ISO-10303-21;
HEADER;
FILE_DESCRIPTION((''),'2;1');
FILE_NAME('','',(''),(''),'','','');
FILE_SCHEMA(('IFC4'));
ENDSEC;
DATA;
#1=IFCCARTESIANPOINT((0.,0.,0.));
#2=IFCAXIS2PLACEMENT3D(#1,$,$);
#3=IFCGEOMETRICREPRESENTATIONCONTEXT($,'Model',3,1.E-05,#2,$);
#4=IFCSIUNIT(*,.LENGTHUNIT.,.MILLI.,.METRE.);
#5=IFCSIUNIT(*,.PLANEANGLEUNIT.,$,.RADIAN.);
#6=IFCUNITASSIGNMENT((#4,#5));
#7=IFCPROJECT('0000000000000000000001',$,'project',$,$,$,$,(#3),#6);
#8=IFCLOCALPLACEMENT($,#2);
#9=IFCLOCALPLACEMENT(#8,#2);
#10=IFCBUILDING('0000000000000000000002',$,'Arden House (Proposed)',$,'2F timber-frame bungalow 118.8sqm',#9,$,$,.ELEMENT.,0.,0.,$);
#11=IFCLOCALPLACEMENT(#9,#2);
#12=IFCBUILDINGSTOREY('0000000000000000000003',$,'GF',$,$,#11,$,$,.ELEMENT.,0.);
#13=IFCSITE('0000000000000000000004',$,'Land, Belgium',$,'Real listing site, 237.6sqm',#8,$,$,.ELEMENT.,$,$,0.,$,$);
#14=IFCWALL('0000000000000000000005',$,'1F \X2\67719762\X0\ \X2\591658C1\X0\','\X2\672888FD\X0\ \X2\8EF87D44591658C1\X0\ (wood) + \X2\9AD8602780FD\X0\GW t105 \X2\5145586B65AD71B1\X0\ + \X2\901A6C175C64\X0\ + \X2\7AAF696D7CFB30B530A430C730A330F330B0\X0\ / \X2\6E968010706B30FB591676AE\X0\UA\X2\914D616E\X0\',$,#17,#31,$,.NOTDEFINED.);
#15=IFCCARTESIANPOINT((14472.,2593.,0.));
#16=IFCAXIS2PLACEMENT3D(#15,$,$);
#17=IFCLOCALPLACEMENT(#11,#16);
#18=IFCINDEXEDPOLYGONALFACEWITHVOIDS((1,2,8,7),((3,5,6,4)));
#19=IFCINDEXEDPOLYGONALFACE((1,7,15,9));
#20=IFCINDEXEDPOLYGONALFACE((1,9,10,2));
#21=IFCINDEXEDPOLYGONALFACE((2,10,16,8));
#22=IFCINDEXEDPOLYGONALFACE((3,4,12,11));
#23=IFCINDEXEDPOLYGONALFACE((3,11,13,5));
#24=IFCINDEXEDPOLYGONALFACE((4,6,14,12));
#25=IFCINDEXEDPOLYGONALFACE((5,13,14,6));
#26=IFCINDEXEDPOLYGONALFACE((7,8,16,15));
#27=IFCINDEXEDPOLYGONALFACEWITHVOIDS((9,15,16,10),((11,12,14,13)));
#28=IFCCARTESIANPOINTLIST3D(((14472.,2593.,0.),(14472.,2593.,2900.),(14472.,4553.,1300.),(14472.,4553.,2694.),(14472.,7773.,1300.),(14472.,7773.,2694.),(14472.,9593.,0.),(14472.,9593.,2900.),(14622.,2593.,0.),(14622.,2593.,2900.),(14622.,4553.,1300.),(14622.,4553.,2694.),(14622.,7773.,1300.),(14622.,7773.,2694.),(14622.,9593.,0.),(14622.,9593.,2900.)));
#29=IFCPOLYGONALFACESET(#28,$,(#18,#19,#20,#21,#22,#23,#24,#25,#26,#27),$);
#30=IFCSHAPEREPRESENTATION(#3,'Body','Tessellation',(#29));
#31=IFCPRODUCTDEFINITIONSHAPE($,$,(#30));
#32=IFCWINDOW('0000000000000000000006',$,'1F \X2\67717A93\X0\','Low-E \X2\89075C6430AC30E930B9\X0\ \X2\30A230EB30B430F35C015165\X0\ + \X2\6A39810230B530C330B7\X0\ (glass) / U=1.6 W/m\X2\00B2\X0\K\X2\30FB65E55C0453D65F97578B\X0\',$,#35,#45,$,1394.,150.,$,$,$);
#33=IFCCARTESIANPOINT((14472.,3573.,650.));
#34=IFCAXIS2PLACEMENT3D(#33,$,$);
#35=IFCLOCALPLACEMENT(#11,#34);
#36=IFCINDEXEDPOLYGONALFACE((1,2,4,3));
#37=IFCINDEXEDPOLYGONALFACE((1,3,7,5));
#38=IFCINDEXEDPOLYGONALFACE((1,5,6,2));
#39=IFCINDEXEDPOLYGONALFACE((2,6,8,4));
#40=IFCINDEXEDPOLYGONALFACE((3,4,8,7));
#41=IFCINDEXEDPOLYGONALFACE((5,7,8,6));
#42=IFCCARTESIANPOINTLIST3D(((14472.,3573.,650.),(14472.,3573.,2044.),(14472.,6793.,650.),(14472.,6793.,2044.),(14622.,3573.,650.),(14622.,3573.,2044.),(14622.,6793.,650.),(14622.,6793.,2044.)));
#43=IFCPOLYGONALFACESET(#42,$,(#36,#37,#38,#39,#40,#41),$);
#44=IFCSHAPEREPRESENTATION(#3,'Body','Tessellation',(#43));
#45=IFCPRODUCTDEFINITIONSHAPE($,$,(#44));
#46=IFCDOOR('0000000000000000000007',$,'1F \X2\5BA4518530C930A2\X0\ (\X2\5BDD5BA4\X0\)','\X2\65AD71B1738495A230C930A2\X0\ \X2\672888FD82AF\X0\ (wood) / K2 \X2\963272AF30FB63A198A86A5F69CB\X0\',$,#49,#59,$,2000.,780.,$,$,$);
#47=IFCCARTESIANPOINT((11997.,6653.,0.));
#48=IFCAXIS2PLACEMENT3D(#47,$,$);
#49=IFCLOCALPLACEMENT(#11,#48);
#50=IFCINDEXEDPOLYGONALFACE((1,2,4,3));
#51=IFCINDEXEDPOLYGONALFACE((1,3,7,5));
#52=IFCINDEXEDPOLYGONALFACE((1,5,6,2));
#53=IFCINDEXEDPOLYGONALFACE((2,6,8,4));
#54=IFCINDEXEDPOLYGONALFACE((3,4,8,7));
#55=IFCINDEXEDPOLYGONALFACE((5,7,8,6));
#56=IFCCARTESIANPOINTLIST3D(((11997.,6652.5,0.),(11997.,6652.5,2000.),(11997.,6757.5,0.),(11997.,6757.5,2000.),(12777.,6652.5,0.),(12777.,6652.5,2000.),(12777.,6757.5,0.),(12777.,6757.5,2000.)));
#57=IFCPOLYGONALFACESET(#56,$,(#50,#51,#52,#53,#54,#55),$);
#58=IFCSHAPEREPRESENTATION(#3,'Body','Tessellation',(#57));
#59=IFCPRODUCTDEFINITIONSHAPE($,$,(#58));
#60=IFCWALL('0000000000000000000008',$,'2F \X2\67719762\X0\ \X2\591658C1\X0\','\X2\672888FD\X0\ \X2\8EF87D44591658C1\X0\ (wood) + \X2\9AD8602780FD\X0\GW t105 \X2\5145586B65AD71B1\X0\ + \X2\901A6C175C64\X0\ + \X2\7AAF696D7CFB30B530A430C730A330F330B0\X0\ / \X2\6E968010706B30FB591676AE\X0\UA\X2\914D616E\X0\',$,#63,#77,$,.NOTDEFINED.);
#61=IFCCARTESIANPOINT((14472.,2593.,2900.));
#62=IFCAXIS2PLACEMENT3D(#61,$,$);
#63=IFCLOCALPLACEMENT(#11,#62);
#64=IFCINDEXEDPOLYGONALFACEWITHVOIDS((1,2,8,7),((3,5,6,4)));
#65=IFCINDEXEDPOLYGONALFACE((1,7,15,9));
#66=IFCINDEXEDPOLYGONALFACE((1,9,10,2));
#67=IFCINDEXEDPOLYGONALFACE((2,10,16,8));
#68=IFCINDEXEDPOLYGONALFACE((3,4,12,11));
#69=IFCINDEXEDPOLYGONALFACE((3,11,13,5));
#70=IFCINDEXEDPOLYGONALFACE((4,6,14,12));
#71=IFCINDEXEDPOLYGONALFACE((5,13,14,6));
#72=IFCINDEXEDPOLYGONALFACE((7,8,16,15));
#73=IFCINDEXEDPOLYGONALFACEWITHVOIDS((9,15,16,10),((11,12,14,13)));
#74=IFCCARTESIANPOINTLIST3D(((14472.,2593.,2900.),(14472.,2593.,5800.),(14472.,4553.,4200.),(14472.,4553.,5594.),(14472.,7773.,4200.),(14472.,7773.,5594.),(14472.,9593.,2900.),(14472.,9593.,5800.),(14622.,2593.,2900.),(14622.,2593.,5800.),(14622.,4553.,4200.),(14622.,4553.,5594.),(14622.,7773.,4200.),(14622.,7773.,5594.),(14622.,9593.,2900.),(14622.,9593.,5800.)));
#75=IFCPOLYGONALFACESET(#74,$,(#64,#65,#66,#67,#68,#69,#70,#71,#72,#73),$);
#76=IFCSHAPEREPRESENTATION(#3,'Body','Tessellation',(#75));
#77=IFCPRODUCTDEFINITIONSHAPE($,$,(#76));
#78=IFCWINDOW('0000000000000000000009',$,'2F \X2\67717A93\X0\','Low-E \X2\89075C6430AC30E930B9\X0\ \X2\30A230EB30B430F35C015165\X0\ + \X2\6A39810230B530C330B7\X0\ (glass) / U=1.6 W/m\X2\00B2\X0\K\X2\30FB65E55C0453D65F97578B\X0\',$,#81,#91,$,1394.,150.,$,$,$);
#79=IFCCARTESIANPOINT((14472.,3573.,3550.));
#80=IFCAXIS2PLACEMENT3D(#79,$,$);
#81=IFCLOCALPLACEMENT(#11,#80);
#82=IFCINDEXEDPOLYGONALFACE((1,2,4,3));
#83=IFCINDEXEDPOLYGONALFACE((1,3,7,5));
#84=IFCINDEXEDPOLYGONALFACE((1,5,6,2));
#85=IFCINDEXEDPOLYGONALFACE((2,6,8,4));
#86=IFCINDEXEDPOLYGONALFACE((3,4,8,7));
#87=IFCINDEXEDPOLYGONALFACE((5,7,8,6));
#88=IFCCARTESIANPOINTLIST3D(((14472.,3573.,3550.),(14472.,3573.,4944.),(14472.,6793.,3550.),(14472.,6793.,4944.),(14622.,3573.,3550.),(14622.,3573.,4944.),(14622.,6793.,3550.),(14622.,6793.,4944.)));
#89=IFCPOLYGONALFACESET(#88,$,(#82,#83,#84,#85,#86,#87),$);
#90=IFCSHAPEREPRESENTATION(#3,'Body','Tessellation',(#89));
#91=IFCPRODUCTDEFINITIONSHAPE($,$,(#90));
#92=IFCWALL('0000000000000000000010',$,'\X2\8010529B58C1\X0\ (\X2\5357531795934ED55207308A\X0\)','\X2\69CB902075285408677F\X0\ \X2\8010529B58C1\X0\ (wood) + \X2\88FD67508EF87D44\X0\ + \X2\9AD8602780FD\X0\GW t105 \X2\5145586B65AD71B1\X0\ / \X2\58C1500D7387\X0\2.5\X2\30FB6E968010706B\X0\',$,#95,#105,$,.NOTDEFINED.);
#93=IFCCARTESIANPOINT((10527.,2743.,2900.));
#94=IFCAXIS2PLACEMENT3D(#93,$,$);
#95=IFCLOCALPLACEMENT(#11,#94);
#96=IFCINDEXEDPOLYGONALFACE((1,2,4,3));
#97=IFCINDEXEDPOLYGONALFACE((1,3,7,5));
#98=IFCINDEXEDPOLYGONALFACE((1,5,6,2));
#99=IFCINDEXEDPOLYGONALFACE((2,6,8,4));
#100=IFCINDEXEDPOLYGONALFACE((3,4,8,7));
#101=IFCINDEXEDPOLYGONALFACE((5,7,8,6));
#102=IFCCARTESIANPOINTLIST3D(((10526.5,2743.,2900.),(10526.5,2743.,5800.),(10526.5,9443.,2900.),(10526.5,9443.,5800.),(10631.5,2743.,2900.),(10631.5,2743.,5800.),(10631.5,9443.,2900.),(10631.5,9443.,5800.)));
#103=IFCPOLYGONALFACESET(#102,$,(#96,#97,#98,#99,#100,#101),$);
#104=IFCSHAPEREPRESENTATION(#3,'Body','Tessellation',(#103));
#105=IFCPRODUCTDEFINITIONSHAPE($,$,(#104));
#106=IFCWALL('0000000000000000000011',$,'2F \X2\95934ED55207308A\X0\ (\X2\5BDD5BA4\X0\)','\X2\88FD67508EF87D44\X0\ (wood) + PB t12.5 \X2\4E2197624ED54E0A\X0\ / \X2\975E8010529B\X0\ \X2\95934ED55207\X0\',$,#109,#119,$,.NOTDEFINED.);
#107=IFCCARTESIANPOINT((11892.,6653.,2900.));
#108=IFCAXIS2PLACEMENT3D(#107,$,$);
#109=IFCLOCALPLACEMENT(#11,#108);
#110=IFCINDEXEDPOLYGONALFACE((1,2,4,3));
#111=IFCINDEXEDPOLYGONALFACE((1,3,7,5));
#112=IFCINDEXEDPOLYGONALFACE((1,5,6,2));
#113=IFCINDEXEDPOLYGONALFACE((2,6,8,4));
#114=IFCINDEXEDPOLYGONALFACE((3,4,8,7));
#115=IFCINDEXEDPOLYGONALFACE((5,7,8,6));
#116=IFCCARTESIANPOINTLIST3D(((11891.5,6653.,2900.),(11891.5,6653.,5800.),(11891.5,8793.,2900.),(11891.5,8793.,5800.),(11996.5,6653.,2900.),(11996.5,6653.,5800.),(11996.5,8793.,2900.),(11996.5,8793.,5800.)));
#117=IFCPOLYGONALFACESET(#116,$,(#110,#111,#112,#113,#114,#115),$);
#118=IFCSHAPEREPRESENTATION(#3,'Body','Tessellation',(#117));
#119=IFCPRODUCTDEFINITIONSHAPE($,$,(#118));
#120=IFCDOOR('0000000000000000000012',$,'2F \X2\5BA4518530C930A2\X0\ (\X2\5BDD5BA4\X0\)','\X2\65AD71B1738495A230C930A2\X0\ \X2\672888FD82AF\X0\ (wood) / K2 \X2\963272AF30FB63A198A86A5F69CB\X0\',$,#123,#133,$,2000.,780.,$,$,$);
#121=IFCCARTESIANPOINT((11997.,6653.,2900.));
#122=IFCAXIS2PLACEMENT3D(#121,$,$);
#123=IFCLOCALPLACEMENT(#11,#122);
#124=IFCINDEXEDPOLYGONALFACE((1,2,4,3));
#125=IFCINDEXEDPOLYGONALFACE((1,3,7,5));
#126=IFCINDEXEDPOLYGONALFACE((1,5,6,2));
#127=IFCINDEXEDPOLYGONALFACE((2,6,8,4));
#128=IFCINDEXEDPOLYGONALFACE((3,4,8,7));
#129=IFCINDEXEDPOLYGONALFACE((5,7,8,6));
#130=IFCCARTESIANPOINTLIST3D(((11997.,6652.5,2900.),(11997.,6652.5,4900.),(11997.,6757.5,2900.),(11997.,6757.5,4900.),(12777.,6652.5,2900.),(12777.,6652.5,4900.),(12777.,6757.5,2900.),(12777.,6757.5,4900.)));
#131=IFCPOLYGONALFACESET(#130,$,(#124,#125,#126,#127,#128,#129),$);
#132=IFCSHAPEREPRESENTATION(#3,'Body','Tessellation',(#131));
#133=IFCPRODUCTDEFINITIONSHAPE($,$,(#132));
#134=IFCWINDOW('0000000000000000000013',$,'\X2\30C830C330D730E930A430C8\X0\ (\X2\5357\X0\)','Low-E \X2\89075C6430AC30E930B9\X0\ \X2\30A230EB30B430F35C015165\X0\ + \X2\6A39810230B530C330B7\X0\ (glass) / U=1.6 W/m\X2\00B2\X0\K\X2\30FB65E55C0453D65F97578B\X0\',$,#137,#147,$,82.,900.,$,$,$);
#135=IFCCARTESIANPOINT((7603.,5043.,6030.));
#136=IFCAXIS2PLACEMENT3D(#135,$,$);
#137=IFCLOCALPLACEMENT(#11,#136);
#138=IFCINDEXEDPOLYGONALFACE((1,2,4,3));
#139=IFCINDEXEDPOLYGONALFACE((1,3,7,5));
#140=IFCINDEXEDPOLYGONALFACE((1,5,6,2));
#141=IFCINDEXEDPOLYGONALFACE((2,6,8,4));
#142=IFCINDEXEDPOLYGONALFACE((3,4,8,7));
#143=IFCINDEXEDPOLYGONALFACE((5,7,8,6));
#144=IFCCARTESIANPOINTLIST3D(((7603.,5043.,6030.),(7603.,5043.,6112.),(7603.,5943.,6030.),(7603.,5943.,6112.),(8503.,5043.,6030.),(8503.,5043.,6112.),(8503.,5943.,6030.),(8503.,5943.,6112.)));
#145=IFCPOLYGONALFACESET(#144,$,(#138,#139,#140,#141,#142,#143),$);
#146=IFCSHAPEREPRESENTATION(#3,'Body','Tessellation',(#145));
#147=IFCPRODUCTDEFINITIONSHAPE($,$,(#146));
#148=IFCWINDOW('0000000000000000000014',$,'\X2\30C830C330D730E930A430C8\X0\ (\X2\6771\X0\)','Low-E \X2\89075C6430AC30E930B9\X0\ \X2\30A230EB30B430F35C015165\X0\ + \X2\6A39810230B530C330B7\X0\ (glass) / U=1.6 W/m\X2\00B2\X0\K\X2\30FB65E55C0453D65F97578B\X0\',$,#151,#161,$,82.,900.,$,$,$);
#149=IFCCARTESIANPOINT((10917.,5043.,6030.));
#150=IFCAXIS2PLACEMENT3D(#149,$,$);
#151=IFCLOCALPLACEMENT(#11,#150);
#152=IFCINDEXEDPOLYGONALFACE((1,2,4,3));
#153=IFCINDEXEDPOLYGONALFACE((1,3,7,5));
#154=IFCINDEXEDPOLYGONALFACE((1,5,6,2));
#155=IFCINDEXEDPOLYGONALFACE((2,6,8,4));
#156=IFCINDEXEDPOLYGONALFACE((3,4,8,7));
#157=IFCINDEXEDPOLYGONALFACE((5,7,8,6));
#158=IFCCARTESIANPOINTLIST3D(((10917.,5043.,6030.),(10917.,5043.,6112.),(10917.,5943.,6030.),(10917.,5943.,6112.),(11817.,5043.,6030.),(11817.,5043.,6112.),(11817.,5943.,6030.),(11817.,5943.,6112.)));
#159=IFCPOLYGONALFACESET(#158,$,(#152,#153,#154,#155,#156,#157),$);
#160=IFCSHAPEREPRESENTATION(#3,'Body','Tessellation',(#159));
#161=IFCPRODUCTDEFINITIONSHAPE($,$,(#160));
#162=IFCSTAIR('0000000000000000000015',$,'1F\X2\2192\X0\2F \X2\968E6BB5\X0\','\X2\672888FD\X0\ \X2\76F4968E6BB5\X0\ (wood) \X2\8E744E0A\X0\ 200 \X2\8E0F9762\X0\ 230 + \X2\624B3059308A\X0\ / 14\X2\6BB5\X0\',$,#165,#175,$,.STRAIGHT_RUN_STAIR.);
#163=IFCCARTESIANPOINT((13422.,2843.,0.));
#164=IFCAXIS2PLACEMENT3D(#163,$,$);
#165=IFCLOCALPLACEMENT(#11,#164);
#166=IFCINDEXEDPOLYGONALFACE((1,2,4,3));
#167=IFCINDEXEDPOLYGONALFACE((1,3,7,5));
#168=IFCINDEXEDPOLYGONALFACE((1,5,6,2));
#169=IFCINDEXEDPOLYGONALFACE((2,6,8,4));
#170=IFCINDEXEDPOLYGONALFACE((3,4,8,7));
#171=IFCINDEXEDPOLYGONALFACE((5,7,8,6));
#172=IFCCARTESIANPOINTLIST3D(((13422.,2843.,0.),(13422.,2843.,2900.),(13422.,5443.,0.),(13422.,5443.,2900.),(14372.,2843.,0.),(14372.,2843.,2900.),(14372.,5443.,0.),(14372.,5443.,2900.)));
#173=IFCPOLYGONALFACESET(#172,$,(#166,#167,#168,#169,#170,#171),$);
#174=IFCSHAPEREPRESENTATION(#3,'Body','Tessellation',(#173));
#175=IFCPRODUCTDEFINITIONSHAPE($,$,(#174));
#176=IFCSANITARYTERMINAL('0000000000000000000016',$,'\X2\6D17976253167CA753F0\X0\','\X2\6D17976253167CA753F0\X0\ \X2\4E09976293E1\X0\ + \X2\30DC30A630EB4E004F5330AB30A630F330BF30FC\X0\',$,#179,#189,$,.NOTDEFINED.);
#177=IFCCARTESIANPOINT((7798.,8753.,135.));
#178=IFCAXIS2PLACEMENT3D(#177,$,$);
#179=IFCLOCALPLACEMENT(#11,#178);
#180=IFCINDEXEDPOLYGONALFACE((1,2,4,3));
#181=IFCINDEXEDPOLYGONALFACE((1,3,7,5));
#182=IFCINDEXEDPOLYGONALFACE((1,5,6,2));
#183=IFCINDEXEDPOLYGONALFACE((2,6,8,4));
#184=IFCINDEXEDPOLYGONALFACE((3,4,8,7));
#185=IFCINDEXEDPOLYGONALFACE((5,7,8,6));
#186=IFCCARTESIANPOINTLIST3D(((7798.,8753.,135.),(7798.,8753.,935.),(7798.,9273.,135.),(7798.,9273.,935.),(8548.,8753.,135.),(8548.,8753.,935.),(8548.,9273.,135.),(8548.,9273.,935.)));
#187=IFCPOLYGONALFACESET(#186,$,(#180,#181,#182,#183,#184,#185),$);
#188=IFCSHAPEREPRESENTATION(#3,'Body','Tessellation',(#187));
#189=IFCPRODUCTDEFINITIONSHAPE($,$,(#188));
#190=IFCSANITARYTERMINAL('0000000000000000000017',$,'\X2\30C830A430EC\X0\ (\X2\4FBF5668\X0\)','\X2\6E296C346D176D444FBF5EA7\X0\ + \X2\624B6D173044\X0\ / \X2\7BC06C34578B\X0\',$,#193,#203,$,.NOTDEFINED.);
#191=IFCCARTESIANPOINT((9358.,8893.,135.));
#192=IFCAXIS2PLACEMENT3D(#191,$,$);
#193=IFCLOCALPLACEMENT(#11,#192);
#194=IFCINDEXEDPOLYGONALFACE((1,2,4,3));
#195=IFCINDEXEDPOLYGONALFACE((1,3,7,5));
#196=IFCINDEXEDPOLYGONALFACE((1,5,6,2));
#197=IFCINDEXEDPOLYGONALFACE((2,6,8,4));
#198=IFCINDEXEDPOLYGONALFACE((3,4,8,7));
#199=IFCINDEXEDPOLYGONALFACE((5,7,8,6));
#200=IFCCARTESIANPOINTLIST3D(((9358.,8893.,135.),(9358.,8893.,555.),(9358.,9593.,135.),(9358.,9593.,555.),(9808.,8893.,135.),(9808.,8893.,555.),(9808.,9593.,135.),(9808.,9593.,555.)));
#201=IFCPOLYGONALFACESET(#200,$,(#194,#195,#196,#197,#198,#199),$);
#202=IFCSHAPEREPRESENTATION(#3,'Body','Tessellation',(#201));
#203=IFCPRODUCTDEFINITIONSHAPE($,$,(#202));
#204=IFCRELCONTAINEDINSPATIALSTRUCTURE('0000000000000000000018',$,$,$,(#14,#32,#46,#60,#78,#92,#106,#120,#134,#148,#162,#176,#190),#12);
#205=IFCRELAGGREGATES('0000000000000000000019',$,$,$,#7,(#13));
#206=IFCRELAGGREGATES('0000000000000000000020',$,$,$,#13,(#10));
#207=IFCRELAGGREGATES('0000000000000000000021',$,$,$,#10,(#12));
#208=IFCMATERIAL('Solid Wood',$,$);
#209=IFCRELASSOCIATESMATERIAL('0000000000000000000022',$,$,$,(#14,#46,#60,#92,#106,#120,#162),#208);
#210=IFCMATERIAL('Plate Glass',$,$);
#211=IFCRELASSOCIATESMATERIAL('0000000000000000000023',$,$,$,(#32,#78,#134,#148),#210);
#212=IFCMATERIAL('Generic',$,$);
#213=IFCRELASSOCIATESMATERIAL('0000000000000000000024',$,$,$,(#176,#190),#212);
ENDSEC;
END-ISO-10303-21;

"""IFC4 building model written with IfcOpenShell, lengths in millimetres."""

from ifc_helpers import new_model, si_unit, frame, frame_2d, origin, place, context, project, spatial, rectangle, extrude, material, element, fill, save


model = new_model("IFC4")

# Units and contexts
model_context = context("Model", 3, precision=1e-05, world=origin())
ifc_project = project(units=[si_unit("LENGTHUNIT", "METRE", prefix="MILLI"), si_unit("PLANEANGLEUNIT", "RADIAN")], contexts=[model_context])

# Site, building, storey
site_placement = place(None, origin())
site = spatial("IfcSite", under=ifc_project, at=site_placement, Name="Land, Belgium", ObjectType="Real listing site, 237.6sqm", CompositionType="ELEMENT", RefElevation=0.0)
building_placement = place(site_placement, origin())
building = spatial("IfcBuilding", under=site, at=building_placement, Name="Arden House (Proposed)", ObjectType="2F timber-frame bungalow 118.8sqm", CompositionType="ELEMENT", ElevationOfRefHeight=0.0, ElevationOfTerrain=0.0)
storey_placement = place(building_placement, origin())
storey = spatial("IfcBuildingStorey", under=building, at=storey_placement, Name="GF", CompositionType="ELEMENT", Elevation=0.0)

# Wall, opening, window
ifc_material_1 = material(Name="Solid Wood")
wall_1_placement = place(storey_placement, frame((14472.0, 2593.0, 0.0)))
wall_1 = element("IfcWall", 1, at=wall_1_placement, inside=storey, material=ifc_material_1, Name="1F 東面 外壁", Description="木製 軸組外壁 (wood) + 高性能GW t105 充填断熱 + 通気層 + 窯業系サイディング / 準耐火・外皮UA配慮", PredefinedType="NOTDEFINED", context=model_context, shape_type="SweptSolid", body=[
    extrude(rectangle(XDim=150.0, YDim=7000.0, at=frame_2d((75.0, 3500.0))), frame((14472.0, 2593.0, 0.0)), (0.0, 0.0, 1.0), 2900.0),
])
opening_1_placement = place(storey_placement, frame((14472.0, 3573.0, 650.0)))
opening_1 = element("IfcOpeningElement", 2, at=opening_1_placement, cuts=wall_1, PredefinedType="NOTDEFINED", context=model_context, shape_type="SweptSolid", body=[
    extrude(rectangle(XDim=150.0, YDim=3220.0, at=frame_2d((75.0, 1610.0))), frame((14472.0, 3573.0, 650.0)), (0.0, 0.0, 1.0), 1394.0),
])
ifc_material_2 = material(Name="Plate Glass")
window_1_placement = place(storey_placement, frame((14472.0, 3573.0, 650.0)))
window_1 = element("IfcWindow", 3, at=window_1_placement, inside=storey, material=ifc_material_2, Name="1F 東窓", Description="Low-E 複層ガラス アルゴン封入 + 樹脂サッシ (glass) / U=1.6 W/m²K・日射取得型", OverallHeight=1394.0, OverallWidth=150.0, context=model_context, shape_type="SweptSolid", body=[
    extrude(rectangle(XDim=150.0, YDim=3220.0, at=frame_2d((75.0, 1610.0))), frame((14472.0, 3573.0, 650.0)), (0.0, 0.0, 1.0), 1394.0),
])
fill(opening_1, window_1)

# Door
door_1_placement = place(storey_placement, frame((11997.0, 6653.0, 0.0)))
element("IfcDoor", 4, at=door_1_placement, inside=storey, material=ifc_material_1, Name="1F 室内ドア (寝室)", Description="断熱玄関ドア 木製芯 (wood) / K2 防犯・採風機構", OverallHeight=2000.0, OverallWidth=780.0, context=model_context, shape_type="SweptSolid", body=[
    extrude(rectangle(XDim=780.0, YDim=105.0, at=frame_2d((390.0, 52.0))), frame((11997.0, 6653.0, 0.0)), (0.0, 0.0, 1.0), 2000.0),
])

# Wall, opening, window
wall_2_placement = place(storey_placement, frame((14472.0, 2593.0, 2900.0)))
wall_2 = element("IfcWall", 5, at=wall_2_placement, inside=storey, material=ifc_material_1, Name="2F 東面 外壁", Description="木製 軸組外壁 (wood) + 高性能GW t105 充填断熱 + 通気層 + 窯業系サイディング / 準耐火・外皮UA配慮", PredefinedType="NOTDEFINED", context=model_context, shape_type="SweptSolid", body=[
    extrude(rectangle(XDim=150.0, YDim=7000.0, at=frame_2d((75.0, 3500.0))), frame((14472.0, 2593.0, 2900.0)), (0.0, 0.0, 1.0), 2900.0),
])
opening_2_placement = place(storey_placement, frame((14472.0, 3573.0, 3550.0)))
opening_2 = element("IfcOpeningElement", 6, at=opening_2_placement, cuts=wall_2, PredefinedType="NOTDEFINED", context=model_context, shape_type="SweptSolid", body=[
    extrude(rectangle(XDim=150.0, YDim=3220.0, at=frame_2d((75.0, 1610.0))), frame((14472.0, 3573.0, 3550.0)), (0.0, 0.0, 1.0), 1394.0),
])
window_2_placement = place(storey_placement, frame((14472.0, 3573.0, 3550.0)))
window_2 = element("IfcWindow", 7, at=window_2_placement, inside=storey, material=ifc_material_2, Name="2F 東窓", Description="Low-E 複層ガラス アルゴン封入 + 樹脂サッシ (glass) / U=1.6 W/m²K・日射取得型", OverallHeight=1394.0, OverallWidth=150.0, context=model_context, shape_type="SweptSolid", body=[
    extrude(rectangle(XDim=150.0, YDim=3220.0, at=frame_2d((75.0, 1610.0))), frame((14472.0, 3573.0, 3550.0)), (0.0, 0.0, 1.0), 1394.0),
])
fill(opening_2, window_2)

# Walls
wall_3_placement = place(storey_placement, frame((10527.0, 2743.0, 2900.0)))
element("IfcWall", 8, at=wall_3_placement, inside=storey, material=ifc_material_1, Name="耐力壁 (南北間仕切り)", Description="構造用合板 耐力壁 (wood) + 製材軸組 + 高性能GW t105 充填断熱 / 壁倍率2.5・準耐火", PredefinedType="NOTDEFINED", context=model_context, shape_type="SweptSolid", body=[
    extrude(rectangle(XDim=105.0, YDim=6700.0, at=frame_2d((52.0, 3350.0))), frame((10527.0, 2743.0, 2900.0)), (0.0, 0.0, 1.0), 2900.0),
])
wall_4_placement = place(storey_placement, frame((11892.0, 6653.0, 2900.0)))
element("IfcWall", 9, at=wall_4_placement, inside=storey, material=ifc_material_1, Name="2F 間仕切り (寝室)", Description="製材軸組 (wood) + PB t12.5 両面仕上 / 非耐力 間仕切", PredefinedType="NOTDEFINED", context=model_context, shape_type="SweptSolid", body=[
    extrude(rectangle(XDim=105.0, YDim=2140.0, at=frame_2d((52.0, 1070.0))), frame((11892.0, 6653.0, 2900.0)), (0.0, 0.0, 1.0), 2900.0),
])

# Door
door_2_placement = place(storey_placement, frame((11997.0, 6653.0, 2900.0)))
element("IfcDoor", 10, at=door_2_placement, inside=storey, material=ifc_material_1, Name="2F 室内ドア (寝室)", Description="断熱玄関ドア 木製芯 (wood) / K2 防犯・採風機構", OverallHeight=2000.0, OverallWidth=780.0, context=model_context, shape_type="SweptSolid", body=[
    extrude(rectangle(XDim=780.0, YDim=105.0, at=frame_2d((390.0, 52.0))), frame((11997.0, 6653.0, 2900.0)), (0.0, 0.0, 1.0), 2000.0),
])

# Windows
window_3_placement = place(storey_placement, frame((7603.0, 5043.0, 6030.0)))
element("IfcWindow", 11, at=window_3_placement, inside=storey, material=ifc_material_2, Name="トップライト (南)", Description="Low-E 複層ガラス アルゴン封入 + 樹脂サッシ (glass) / U=1.6 W/m²K・日射取得型", OverallHeight=82.0, OverallWidth=900.0, context=model_context, shape_type="SweptSolid", body=[
    extrude(rectangle(XDim=900.0, YDim=900.0, at=frame_2d((450.0, 450.0))), frame((7603.0, 5043.0, 6030.0)), (0.0, 0.0, 1.0), 82.0),
])
window_4_placement = place(storey_placement, frame((10917.0, 5043.0, 6030.0)))
element("IfcWindow", 12, at=window_4_placement, inside=storey, material=ifc_material_2, Name="トップライト (東)", Description="Low-E 複層ガラス アルゴン封入 + 樹脂サッシ (glass) / U=1.6 W/m²K・日射取得型", OverallHeight=82.0, OverallWidth=900.0, context=model_context, shape_type="SweptSolid", body=[
    extrude(rectangle(XDim=900.0, YDim=900.0, at=frame_2d((450.0, 450.0))), frame((10917.0, 5043.0, 6030.0)), (0.0, 0.0, 1.0), 82.0),
])

# Stair
stair_placement = place(storey_placement, frame((13422.0, 2843.0, 0.0)))
element("IfcStair", 13, at=stair_placement, inside=storey, material=ifc_material_1, Name="1F→2F 階段", Description="木製 直階段 (wood) 蹴上 200 踏面 230 + 手すり / 14段", PredefinedType="STRAIGHT_RUN_STAIR", context=model_context, shape_type="SweptSolid", body=[
    extrude(rectangle(XDim=950.0, YDim=2600.0, at=frame_2d((475.0, 1300.0))), frame((13422.0, 2843.0, 0.0)), (0.0, 0.0, 1.0), 2900.0),
])

# Sanitary terminals
ifc_material_3 = material(Name="Generic")
sanitary_terminal_1_placement = place(storey_placement, frame((7798.0, 8753.0, 135.0)))
element("IfcSanitaryTerminal", 14, at=sanitary_terminal_1_placement, inside=storey, material=ifc_material_3, Name="洗面化粧台", Description="洗面化粧台 三面鏡 + ボウル一体カウンター", PredefinedType="NOTDEFINED", context=model_context, shape_type="SweptSolid", body=[
    extrude(rectangle(XDim=750.0, YDim=520.0, at=frame_2d((375.0, 260.0))), frame((7798.0, 8753.0, 135.0)), (0.0, 0.0, 1.0), 800.0),
])
sanitary_terminal_2_placement = place(storey_placement, frame((9358.0, 8893.0, 135.0)))
element("IfcSanitaryTerminal", 15, at=sanitary_terminal_2_placement, inside=storey, material=ifc_material_3, Name="トイレ (便器)", Description="温水洗浄便座 + 手洗い / 節水型", PredefinedType="NOTDEFINED", context=model_context, shape_type="SweptSolid", body=[
    extrude(rectangle(XDim=450.0, YDim=700.0, at=frame_2d((225.0, 350.0))), frame((9358.0, 8893.0, 135.0)), (0.0, 0.0, 1.0), 420.0),
])

save(model, "model.ifc")
